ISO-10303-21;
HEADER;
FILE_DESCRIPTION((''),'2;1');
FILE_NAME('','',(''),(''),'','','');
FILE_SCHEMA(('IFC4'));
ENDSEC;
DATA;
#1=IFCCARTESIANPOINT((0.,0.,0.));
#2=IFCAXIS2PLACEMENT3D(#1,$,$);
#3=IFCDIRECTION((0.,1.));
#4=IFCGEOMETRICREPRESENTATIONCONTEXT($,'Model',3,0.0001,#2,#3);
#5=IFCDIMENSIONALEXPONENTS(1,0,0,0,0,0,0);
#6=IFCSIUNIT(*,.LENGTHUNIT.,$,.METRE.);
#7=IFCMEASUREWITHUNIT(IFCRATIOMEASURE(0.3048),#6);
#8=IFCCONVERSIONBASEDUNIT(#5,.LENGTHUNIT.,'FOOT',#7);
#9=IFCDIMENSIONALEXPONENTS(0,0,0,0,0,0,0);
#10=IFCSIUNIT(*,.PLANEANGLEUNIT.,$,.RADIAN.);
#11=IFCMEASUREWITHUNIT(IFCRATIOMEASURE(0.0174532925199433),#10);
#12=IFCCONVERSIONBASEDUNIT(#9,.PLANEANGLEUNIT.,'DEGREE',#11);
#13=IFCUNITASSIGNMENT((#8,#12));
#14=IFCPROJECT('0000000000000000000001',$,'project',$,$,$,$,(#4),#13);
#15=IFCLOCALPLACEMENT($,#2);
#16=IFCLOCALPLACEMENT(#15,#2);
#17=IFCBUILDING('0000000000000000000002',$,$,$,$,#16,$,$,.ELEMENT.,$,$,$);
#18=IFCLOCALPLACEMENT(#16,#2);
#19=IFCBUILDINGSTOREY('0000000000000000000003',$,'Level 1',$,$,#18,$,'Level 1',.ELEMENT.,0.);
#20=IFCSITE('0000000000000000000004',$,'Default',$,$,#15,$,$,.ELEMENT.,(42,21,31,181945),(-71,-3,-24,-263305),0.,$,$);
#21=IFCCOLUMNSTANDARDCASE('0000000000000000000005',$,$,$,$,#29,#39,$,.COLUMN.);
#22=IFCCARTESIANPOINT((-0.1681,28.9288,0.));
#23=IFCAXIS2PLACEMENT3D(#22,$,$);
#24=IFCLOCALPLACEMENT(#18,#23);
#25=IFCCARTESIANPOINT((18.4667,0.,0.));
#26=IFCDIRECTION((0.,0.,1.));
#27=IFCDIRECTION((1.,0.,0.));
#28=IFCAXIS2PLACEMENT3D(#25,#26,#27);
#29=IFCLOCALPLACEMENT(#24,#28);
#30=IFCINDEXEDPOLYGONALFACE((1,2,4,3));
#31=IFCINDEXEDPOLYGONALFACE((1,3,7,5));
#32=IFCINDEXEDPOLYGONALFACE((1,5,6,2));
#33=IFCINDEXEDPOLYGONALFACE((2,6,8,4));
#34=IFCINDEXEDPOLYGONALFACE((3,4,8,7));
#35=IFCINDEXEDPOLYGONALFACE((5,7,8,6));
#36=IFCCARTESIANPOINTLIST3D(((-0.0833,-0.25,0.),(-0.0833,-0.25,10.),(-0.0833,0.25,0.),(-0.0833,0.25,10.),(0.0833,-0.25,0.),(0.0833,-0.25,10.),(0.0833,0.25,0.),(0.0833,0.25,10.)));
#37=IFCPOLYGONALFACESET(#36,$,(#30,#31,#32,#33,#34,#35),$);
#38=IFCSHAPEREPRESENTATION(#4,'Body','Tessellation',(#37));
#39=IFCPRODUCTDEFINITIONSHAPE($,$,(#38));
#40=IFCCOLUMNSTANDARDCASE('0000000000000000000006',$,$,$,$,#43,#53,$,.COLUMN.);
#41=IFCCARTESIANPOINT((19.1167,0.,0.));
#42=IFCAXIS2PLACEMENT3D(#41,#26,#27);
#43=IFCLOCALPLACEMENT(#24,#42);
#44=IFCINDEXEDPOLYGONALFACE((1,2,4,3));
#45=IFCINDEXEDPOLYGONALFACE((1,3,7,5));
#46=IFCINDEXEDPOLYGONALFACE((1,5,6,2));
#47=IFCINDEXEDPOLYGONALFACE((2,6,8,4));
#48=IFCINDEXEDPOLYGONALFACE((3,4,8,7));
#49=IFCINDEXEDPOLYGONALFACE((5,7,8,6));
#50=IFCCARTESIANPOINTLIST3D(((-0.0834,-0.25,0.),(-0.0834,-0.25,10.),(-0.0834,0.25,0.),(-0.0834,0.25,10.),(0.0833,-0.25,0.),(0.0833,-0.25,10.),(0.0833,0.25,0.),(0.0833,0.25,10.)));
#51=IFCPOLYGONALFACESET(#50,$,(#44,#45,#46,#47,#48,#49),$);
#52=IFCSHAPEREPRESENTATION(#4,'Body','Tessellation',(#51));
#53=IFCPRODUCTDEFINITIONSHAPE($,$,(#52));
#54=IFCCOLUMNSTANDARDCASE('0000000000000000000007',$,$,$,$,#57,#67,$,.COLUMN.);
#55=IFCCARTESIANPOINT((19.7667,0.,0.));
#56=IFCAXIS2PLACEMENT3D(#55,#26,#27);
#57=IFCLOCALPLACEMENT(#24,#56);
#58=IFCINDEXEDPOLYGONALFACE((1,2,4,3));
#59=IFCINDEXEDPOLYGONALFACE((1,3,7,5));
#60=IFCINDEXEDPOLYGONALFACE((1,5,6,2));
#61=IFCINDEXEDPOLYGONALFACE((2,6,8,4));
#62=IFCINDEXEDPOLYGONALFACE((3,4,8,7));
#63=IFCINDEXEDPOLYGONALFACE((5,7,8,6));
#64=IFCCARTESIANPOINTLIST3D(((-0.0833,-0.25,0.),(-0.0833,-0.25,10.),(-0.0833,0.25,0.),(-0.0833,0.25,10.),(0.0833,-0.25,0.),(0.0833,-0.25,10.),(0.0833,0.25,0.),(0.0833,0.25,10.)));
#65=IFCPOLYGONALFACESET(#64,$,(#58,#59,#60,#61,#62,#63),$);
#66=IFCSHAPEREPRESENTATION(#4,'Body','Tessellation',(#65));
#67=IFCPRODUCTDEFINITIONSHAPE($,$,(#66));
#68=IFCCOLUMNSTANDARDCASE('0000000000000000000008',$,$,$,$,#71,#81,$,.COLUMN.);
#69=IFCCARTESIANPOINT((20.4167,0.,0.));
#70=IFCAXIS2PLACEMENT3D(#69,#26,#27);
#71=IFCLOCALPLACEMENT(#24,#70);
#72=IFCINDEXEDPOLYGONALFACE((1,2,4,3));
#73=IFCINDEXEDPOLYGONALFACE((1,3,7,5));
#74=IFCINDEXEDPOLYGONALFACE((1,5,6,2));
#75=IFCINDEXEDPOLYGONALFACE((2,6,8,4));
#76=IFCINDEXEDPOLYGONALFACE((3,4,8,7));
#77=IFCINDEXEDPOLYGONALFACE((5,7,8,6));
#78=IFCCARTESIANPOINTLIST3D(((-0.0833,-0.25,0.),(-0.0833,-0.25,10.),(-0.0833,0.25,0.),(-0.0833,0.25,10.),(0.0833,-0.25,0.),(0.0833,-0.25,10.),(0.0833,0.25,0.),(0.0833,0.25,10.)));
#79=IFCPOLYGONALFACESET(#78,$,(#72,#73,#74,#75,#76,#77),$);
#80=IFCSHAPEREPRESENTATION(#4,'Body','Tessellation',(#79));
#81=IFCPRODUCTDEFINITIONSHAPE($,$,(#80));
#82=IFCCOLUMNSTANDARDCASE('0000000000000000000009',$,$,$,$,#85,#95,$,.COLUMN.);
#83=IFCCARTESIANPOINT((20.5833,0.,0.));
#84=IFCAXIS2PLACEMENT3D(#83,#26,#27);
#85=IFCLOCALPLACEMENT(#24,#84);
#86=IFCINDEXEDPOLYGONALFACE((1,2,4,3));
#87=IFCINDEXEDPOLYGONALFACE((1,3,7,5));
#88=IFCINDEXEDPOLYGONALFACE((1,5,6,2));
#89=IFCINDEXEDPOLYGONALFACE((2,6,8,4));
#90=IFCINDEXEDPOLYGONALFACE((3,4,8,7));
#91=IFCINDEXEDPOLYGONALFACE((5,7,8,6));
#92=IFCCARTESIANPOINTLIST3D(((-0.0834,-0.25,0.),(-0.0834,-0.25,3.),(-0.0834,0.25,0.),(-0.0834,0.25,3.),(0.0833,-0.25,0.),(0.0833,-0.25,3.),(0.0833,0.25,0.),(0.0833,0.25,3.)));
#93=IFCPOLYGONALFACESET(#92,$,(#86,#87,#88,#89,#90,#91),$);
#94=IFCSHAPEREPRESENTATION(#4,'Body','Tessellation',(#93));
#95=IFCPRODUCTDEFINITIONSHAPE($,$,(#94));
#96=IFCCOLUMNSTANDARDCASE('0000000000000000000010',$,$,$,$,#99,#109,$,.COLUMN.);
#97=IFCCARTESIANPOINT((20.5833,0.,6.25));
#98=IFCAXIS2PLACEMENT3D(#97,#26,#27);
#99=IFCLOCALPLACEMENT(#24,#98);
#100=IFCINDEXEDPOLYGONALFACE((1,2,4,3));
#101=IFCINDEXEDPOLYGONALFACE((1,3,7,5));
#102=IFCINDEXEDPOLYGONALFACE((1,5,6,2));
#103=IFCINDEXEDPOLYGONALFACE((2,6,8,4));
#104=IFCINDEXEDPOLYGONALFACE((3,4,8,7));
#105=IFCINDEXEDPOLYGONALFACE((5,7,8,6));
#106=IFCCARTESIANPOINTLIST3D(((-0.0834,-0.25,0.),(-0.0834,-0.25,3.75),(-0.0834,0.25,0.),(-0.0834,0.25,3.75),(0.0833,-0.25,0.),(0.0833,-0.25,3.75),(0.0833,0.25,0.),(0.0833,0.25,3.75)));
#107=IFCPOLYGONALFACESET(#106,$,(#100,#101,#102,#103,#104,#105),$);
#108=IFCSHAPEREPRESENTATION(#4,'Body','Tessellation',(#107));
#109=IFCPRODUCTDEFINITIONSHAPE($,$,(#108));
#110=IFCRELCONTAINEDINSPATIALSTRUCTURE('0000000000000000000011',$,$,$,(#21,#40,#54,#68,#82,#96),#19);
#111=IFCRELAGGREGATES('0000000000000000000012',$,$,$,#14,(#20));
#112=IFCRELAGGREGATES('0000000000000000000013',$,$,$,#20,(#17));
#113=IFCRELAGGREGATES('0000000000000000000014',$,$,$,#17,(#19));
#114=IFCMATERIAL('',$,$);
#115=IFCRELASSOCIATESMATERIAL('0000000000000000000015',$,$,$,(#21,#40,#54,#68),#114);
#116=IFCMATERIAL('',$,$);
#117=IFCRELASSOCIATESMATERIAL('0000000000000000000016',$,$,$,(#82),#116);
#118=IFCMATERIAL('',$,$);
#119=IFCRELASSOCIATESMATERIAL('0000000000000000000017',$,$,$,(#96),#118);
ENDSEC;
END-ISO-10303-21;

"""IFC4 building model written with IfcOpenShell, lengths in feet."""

from ifc_helpers import new_model, entity, si_unit, converted_unit, direction, frame, origin, place, context, project, spatial, rectangle, extrude, material, element, save


model = new_model("IFC4")

# Units and contexts
model_context = context("Model", 3, precision=0.0001, world=origin(), true_north=direction((0.0, 1.0)))
ifc_project = project(units=[converted_unit("LENGTHUNIT", "FOOT", entity("IfcRatioMeasure", 0.3048), si_unit("LENGTHUNIT", "METRE"), dimensions=[1, 0, 0, 0, 0, 0, 0]), converted_unit("PLANEANGLEUNIT", "DEGREE", entity("IfcRatioMeasure", 0.0174532925199433), si_unit("PLANEANGLEUNIT", "RADIAN"), dimensions=[0, 0, 0, 0, 0, 0, 0])], contexts=[model_context])

# Site, building, storey
site_placement = place(None, origin())
site = spatial("IfcSite", under=ifc_project, at=site_placement, Name="Default", CompositionType="ELEMENT", RefLatitude=(42, 21, 31, 181945), RefLongitude=(-71, -3, -24, -263305), RefElevation=0.0)
building_placement = place(site_placement, origin())
building = spatial("IfcBuilding", under=site, at=building_placement, CompositionType="ELEMENT")
storey_placement = place(building_placement, origin())
storey = spatial("IfcBuildingStorey", under=building, at=storey_placement, Name="Level 1", LongName="Level 1", CompositionType="ELEMENT", Elevation=0.0)

# Columns
ifc_material_1 = material(Name="")
placement = place(storey_placement, frame((-0.1681, 28.9288, 0.0)))
for number, where, z_axis, x_axis in (
    (1, (18.4667, 0.0, 0.0), (0.0, 0.0, 1.0), (1.0, 0.0, 0.0)),
    (2, (19.1167, 0.0, 0.0), (0.0, 0.0, 1.0), (1.0, 0.0, 0.0)),
    (3, (19.7667, 0.0, 0.0), (0.0, 0.0, 1.0), (1.0, 0.0, 0.0)),
    (4, (20.4167, 0.0, 0.0), (0.0, 0.0, 1.0), (1.0, 0.0, 0.0)),
):
    element("IfcColumnStandardCase", number, at=place(placement, frame(where, z_axis=z_axis, x_axis=x_axis)), inside=storey, material=ifc_material_1, PredefinedType="COLUMN", context=model_context, shape_type="SweptSolid", body=[
        extrude(rectangle(XDim=0.1667, YDim=0.5), origin(), (0.0, 0.0, 1.0), 10.0),
    ])
ifc_material_2 = material(Name="")
for number, where, z_axis, x_axis in (
    (5, (20.5833, 0.0, 0.0), (0.0, 0.0, 1.0), (1.0, 0.0, 0.0)),
):
    element("IfcColumnStandardCase", number, at=place(placement, frame(where, z_axis=z_axis, x_axis=x_axis)), inside=storey, material=ifc_material_2, PredefinedType="COLUMN", context=model_context, shape_type="SweptSolid", body=[
        extrude(rectangle(XDim=0.1667, YDim=0.5), origin(), (0.0, 0.0, 1.0), 3.0),
    ])
ifc_material_3 = material(Name="")
for number, where, z_axis, x_axis in (
    (6, (20.5833, 0.0, 6.25), (0.0, 0.0, 1.0), (1.0, 0.0, 0.0)),
):
    element("IfcColumnStandardCase", number, at=place(placement, frame(where, z_axis=z_axis, x_axis=x_axis)), inside=storey, material=ifc_material_3, PredefinedType="COLUMN", context=model_context, shape_type="SweptSolid", body=[
        extrude(rectangle(XDim=0.1667, YDim=0.5), origin(), (0.0, 0.0, 1.0), 3.75),
    ])

save(model, "model.ifc")
